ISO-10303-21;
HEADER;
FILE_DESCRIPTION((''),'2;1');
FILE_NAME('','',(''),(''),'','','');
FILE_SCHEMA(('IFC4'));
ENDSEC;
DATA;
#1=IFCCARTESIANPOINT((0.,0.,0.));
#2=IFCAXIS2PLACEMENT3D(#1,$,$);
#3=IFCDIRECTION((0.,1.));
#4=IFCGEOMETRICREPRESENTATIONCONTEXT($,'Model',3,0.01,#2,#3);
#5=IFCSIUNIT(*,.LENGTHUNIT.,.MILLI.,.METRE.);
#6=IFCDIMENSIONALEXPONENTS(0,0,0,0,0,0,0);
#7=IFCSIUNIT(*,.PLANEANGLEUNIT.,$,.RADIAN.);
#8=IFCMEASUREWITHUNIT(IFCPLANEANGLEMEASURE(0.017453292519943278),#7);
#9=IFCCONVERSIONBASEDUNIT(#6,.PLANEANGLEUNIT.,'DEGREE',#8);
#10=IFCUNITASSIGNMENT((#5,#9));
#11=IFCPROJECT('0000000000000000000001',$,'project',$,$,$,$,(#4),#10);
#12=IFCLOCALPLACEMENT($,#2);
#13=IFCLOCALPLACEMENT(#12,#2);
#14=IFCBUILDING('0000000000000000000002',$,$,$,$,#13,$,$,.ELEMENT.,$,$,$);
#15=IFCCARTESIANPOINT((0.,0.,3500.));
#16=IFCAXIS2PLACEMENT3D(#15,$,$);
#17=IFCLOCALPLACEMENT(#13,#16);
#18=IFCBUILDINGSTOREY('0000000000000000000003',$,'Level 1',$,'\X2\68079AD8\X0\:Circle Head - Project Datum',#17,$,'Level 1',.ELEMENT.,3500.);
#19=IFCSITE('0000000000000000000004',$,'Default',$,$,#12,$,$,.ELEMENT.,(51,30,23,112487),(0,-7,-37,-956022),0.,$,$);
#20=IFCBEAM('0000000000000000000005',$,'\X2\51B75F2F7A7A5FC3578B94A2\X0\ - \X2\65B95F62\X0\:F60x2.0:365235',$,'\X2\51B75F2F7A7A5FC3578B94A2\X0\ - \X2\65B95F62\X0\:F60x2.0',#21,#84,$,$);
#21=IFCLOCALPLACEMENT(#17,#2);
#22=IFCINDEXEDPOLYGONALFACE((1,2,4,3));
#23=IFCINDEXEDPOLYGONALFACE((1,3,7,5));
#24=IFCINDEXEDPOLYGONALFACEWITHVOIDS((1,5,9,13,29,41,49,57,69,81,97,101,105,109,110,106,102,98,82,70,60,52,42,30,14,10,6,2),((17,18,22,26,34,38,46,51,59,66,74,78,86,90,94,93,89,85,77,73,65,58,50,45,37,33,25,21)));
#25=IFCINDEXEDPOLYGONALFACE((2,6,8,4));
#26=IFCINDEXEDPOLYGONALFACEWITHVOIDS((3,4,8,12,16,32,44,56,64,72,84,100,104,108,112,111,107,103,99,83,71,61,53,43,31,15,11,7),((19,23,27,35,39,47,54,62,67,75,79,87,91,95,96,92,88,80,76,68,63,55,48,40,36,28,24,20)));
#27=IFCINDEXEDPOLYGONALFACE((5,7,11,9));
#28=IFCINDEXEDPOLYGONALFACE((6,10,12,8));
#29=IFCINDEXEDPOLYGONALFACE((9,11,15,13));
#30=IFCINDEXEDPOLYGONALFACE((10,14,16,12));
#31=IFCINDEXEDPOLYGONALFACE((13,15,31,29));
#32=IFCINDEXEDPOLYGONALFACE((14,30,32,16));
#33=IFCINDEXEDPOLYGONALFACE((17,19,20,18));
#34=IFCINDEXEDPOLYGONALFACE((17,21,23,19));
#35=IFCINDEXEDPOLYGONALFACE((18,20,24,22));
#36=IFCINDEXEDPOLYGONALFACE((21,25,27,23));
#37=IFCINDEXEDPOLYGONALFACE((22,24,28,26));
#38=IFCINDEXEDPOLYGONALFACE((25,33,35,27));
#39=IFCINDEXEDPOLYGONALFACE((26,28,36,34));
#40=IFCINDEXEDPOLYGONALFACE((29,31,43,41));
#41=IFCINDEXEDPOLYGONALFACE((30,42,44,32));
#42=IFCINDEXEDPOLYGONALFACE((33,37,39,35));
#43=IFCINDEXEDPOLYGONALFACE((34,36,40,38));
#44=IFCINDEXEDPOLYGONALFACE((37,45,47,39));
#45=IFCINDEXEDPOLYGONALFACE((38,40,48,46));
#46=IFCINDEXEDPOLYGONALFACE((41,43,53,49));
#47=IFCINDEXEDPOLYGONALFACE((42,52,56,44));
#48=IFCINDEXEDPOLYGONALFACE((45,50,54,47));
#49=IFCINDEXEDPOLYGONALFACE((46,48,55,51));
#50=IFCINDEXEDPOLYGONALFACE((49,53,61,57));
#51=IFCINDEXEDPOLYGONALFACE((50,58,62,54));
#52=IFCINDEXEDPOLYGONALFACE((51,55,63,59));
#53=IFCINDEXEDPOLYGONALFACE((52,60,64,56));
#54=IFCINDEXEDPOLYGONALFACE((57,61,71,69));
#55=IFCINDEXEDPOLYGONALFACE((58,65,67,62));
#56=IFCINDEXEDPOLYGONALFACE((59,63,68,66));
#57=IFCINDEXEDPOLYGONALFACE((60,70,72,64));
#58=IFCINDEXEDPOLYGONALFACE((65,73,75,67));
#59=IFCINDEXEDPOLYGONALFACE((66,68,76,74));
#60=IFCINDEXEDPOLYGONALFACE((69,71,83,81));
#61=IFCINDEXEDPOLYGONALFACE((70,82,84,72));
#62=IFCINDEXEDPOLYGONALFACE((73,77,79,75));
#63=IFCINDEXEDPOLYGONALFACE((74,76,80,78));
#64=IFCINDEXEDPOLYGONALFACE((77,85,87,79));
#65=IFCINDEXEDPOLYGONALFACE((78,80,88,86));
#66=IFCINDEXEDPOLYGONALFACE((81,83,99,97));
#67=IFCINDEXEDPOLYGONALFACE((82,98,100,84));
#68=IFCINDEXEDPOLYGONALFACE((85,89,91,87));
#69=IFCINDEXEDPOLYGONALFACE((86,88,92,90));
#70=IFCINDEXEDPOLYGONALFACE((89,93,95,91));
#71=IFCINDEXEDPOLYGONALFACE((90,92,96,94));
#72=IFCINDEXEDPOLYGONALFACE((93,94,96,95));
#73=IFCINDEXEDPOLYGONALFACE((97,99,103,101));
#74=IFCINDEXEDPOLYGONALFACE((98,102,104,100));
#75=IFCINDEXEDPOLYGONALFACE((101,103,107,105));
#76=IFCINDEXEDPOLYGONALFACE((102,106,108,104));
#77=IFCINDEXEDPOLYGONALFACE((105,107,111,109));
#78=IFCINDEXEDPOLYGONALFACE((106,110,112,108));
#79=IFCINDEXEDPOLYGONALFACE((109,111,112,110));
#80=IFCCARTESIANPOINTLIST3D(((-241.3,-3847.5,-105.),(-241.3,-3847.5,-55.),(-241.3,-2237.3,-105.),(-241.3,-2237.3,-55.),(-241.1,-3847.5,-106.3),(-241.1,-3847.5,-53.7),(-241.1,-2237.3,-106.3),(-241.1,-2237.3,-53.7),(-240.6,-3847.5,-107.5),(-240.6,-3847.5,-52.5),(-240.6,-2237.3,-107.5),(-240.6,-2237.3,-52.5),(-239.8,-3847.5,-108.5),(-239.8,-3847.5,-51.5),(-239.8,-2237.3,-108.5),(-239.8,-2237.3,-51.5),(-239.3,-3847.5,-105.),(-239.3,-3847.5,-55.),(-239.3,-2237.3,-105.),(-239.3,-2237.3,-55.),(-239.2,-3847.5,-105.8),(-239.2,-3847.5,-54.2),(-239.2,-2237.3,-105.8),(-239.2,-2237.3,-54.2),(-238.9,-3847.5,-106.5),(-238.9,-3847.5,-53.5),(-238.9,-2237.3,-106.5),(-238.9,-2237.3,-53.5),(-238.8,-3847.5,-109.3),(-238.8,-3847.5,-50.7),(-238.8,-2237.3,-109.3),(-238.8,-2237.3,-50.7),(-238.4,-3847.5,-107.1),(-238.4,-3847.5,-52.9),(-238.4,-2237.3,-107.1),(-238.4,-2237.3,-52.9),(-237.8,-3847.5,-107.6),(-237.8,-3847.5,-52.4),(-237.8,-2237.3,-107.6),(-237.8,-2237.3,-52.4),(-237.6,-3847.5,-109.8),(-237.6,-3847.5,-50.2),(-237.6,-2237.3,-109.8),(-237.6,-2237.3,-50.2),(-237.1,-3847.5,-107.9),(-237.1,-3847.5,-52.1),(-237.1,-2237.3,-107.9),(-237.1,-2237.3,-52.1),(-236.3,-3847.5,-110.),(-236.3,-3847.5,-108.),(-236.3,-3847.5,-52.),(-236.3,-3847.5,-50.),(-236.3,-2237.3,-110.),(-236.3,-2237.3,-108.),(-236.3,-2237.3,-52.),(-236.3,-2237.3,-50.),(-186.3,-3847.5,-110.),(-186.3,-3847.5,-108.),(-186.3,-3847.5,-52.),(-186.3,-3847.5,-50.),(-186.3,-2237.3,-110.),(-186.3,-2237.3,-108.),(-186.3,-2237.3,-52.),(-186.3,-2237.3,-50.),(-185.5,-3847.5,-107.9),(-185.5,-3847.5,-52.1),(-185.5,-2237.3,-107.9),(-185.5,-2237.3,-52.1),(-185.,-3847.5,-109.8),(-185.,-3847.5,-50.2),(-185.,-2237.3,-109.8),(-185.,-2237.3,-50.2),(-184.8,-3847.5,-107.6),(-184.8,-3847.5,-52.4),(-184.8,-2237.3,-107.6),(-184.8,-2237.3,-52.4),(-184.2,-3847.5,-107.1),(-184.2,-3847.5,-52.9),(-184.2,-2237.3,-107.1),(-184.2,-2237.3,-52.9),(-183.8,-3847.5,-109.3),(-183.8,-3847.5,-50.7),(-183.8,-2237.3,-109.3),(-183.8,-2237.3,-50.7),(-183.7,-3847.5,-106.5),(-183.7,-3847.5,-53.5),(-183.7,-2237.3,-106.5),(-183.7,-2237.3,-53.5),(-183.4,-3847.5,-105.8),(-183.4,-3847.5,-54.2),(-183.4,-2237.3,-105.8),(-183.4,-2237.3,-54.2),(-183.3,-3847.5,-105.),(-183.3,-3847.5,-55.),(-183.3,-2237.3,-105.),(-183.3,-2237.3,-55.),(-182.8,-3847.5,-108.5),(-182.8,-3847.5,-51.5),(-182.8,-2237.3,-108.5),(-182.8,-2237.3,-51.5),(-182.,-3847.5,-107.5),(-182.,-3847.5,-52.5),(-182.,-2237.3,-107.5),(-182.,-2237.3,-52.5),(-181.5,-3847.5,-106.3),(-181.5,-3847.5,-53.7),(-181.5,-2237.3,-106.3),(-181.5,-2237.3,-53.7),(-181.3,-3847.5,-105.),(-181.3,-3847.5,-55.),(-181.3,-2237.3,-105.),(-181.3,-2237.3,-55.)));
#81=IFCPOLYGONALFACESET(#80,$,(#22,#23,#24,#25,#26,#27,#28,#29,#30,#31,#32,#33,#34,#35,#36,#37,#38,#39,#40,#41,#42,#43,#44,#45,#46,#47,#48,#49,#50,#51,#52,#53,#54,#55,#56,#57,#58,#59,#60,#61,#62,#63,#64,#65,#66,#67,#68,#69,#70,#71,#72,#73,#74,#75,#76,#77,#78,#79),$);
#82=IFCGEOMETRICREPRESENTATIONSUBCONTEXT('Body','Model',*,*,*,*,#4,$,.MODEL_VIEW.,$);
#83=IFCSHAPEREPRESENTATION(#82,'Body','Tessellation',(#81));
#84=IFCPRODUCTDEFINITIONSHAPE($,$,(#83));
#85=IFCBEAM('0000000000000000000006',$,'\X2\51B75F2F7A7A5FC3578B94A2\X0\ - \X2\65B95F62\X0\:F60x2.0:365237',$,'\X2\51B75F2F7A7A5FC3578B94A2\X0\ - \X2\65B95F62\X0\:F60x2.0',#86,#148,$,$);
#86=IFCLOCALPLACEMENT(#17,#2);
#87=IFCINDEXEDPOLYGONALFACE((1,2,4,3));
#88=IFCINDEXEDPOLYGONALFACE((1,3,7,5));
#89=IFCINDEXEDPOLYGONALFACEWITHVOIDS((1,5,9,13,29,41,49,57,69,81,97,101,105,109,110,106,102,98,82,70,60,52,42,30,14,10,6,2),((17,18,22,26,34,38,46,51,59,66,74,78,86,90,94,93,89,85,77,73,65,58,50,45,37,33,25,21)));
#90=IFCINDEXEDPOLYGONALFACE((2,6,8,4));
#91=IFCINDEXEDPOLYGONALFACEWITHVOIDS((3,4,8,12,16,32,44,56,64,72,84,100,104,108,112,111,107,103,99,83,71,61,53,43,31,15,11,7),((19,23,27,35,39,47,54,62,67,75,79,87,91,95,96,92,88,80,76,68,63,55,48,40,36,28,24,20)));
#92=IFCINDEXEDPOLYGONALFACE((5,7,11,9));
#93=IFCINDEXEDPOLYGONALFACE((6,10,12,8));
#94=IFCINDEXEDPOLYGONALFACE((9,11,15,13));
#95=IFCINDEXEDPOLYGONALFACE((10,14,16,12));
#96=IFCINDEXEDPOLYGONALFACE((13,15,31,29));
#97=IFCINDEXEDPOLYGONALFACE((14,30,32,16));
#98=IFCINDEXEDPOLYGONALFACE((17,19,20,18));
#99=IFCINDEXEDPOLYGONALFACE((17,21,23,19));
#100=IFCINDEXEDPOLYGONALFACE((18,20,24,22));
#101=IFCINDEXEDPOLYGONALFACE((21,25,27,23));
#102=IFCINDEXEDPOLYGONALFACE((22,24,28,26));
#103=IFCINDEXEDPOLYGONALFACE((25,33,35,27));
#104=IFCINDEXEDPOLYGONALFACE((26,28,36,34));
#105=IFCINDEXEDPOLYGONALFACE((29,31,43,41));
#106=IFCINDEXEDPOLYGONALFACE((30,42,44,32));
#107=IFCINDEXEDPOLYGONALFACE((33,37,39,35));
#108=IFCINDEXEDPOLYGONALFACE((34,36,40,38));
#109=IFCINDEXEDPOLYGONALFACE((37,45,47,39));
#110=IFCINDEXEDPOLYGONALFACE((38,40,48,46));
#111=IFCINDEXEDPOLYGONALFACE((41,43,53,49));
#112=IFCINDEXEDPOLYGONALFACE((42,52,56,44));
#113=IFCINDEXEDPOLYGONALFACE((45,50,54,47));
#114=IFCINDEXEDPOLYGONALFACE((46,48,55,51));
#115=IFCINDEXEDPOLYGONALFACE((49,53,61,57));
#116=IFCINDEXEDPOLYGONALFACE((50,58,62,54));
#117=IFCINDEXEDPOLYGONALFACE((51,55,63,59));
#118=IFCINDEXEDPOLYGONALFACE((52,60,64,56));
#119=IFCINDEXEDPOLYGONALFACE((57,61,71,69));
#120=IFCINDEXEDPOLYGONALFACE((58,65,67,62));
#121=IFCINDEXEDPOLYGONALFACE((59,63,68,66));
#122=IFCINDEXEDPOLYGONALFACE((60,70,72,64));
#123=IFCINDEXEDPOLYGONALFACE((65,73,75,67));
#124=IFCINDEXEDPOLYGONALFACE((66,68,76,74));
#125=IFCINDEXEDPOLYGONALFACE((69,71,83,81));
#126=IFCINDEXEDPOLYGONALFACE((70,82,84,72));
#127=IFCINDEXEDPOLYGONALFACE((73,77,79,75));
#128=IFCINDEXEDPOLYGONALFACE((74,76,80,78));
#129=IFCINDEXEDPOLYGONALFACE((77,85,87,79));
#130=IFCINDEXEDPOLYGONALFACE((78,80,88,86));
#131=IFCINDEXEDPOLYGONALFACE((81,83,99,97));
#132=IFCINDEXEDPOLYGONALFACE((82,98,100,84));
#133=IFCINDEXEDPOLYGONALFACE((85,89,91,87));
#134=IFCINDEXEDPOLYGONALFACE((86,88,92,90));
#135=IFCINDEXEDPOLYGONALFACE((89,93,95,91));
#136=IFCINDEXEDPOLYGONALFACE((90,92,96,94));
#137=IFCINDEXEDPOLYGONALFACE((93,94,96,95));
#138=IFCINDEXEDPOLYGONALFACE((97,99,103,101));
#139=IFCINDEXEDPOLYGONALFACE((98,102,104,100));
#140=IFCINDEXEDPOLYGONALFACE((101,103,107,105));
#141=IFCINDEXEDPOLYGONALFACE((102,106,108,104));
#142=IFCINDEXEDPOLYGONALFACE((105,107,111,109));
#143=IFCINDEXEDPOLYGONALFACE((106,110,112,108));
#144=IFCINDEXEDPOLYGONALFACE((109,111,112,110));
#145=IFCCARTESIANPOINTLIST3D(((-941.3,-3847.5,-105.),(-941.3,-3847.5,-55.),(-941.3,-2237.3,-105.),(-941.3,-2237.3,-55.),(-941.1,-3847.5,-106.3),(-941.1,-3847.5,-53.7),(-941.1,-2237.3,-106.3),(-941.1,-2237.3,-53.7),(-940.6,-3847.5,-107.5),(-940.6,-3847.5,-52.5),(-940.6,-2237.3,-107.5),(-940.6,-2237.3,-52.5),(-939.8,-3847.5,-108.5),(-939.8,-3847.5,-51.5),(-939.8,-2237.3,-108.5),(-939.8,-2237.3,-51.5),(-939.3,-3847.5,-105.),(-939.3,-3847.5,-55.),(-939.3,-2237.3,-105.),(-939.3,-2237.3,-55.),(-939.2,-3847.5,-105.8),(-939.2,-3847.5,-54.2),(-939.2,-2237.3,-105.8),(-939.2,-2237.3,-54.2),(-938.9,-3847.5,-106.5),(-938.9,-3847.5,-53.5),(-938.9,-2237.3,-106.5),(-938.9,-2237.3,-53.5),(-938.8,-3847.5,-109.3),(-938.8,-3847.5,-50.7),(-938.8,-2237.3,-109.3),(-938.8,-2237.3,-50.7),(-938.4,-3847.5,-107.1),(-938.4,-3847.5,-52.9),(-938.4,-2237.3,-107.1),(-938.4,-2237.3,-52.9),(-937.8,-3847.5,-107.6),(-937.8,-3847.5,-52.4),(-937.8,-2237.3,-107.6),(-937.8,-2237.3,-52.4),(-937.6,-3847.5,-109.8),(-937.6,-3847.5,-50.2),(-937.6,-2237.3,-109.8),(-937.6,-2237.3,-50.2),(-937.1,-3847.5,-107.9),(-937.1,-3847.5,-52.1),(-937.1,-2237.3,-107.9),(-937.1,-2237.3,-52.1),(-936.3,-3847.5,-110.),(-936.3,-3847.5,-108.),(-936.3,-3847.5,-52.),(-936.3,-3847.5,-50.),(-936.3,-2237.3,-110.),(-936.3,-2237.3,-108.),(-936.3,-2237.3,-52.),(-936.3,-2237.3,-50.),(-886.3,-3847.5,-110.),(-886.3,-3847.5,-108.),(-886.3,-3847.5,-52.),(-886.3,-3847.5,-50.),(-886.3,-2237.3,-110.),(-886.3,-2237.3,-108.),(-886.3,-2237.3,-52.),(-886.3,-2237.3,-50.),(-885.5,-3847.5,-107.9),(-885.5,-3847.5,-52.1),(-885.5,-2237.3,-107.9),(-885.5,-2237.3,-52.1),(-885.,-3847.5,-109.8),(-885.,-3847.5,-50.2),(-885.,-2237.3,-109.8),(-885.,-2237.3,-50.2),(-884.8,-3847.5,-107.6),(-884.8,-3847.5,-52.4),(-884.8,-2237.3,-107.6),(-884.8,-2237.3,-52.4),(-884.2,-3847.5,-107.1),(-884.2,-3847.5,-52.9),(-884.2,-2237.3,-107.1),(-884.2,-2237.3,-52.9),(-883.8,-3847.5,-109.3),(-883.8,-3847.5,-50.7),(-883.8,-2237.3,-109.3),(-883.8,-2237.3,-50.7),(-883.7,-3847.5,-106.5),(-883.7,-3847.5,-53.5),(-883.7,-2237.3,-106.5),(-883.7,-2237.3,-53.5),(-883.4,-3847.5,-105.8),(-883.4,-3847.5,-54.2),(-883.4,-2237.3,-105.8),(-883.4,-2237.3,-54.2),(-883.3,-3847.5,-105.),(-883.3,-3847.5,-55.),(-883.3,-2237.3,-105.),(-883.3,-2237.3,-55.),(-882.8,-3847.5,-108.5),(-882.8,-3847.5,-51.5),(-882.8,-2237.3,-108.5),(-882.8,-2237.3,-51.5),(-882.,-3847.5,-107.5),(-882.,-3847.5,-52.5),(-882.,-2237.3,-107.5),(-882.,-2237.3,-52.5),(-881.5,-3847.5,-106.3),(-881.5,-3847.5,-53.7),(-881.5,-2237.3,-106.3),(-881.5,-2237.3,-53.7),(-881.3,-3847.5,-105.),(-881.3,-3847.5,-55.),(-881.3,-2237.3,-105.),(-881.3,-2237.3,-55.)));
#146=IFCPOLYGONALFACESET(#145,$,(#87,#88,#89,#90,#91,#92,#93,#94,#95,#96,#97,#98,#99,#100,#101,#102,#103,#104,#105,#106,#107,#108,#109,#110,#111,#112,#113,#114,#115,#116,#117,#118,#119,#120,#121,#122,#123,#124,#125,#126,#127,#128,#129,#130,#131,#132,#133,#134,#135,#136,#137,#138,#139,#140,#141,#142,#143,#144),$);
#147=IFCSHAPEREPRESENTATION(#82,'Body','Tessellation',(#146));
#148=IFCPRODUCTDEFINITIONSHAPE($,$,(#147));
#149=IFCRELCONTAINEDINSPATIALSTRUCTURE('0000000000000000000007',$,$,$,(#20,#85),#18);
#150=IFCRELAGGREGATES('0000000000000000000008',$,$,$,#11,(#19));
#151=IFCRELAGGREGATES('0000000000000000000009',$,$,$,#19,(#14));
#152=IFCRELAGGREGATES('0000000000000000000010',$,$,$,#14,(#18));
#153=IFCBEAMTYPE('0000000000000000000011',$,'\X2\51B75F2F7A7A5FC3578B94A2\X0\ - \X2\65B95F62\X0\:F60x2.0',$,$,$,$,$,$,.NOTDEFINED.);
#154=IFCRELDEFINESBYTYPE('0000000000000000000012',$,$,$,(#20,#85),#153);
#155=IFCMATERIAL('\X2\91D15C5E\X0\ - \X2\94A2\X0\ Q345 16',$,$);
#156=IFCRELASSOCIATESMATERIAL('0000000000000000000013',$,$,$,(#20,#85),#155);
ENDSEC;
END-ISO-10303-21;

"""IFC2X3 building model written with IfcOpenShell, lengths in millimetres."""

from ifc_helpers import new_model, entity, si_unit, converted_unit, direction, frame, frame_2d, origin, place, context, subcontext, project, spatial, polyline, circle_curve, parameter, trimmed, segment, composite_curve, outline, extrude, material, type_object, element, save


model = new_model("IFC2X3")

# Units and contexts
model_context = context("Model", 3, precision=0.01, world=origin(), true_north=direction((0.0, 1.0)))
body_context = subcontext(model_context, "Body", "Model", "MODEL_VIEW")
ifc_project = project(units=[si_unit("LENGTHUNIT", "METRE", prefix="MILLI"), converted_unit("PLANEANGLEUNIT", "DEGREE", entity("IfcPlaneAngleMeasure", 0.017453292519943278), si_unit("PLANEANGLEUNIT", "RADIAN"), dimensions=[0, 0, 0, 0, 0, 0, 0])], contexts=[model_context])

# Site, building, storey
site_placement = place(None, origin())
site = spatial("IfcSite", under=ifc_project, at=site_placement, Name="Default", CompositionType="ELEMENT", RefLatitude=(51, 30, 23, 112487), RefLongitude=(0, -7, -37, -956022), RefElevation=0.0)
building_placement = place(site_placement, origin())
building = spatial("IfcBuilding", under=site, at=building_placement, CompositionType="ELEMENT")
storey_placement = place(building_placement, frame((0.0, 0.0, 3500.0)))
storey = spatial("IfcBuildingStorey", under=building, at=storey_placement, Name="Level 1", ObjectType="标高:Circle Head - Project Datum", LongName="Level 1", CompositionType="ELEMENT", Elevation=3500.0)

# Beams
ifc_material_1 = material(Name="金属 - 钢 Q345 16")
beam_type_1 = type_object("IfcBeamType", Name="冷弯空心型钢 - 方形:F60x2.0", PredefinedType="NOTDEFINED")
beam_1_placement = place(storey_placement, frame((-211.3, -3815.6, -50.0), z_axis=(0.0, 0.0, 1.0), x_axis=(0.0, 1.0, 0.0)))
element("IfcBeam", 1, at=beam_1_placement, inside=storey, type_object=beam_type_1, material=ifc_material_1, Name="冷弯空心型钢 - 方形:F60x2.0:365235", ObjectType="冷弯空心型钢 - 方形:F60x2.0", context=body_context, shape_type="SweptSolid", body=[
    extrude(outline(composite_curve([segment(polyline([(-25.0, -30.0), (25.0, -30.0)]), True, "CONTINUOUS"), segment(trimmed(circle_curve(frame_2d((25.0, -25.0), x_axis=(1.0, 0.0)), 5.0), [parameter(270.0)], [parameter(360.0)], True, "PARAMETER"), True, "CONTINUOUS"), segment(polyline([(30.0, -25.0), (30.0, 25.0)]), True, "CONTINUOUS"), segment(trimmed(circle_curve(frame_2d((25.0, 25.0), x_axis=(1.0, 0.0)), 5.0), [parameter(360.0)], [parameter(90.0)], True, "PARAMETER"), True, "CONTINUOUS"), segment(polyline([(25.0, 30.0), (-25.0, 30.0)]), True, "CONTINUOUS"), segment(trimmed(circle_curve(frame_2d((-25.0, 25.0), x_axis=(1.0, 0.0)), 5.0), [parameter(90.0)], [parameter(180.0)], True, "PARAMETER"), True, "CONTINUOUS"), segment(polyline([(-30.0, 25.0), (-30.0, -25.0)]), True, "CONTINUOUS"), segment(trimmed(circle_curve(frame_2d((-25.0, -25.0), x_axis=(1.0, 0.0)), 5.0), [parameter(180.0)], [parameter(270.0)], True, "PARAMETER"), True, "CONTINUOUS")], self_intersect=False), holes=[composite_curve([segment(trimmed(circle_curve(frame_2d((-25.0, -25.0), x_axis=(1.0, 0.0)), 3.0), [parameter(180.0)], [parameter(270.0)], True, "PARAMETER"), False, "CONTINUOUS"), segment(polyline([(-28.0, -25.0), (-28.0, 25.0)]), True, "CONTINUOUS"), segment(trimmed(circle_curve(frame_2d((-25.0, 25.0), x_axis=(1.0, 0.0)), 3.0), [parameter(90.0)], [parameter(180.0)], True, "PARAMETER"), False, "CONTINUOUS"), segment(polyline([(-25.0, 28.0), (25.0, 28.0)]), True, "CONTINUOUS"), segment(trimmed(circle_curve(frame_2d((25.0, 25.0), x_axis=(1.0, 0.0)), 3.0), [parameter(0.0)], [parameter(90.0)], True, "PARAMETER"), False, "CONTINUOUS"), segment(polyline([(28.0, 25.0), (28.0, -25.0)]), True, "CONTINUOUS"), segment(trimmed(circle_curve(frame_2d((25.0, -25.0), x_axis=(1.0, 0.0)), 3.0), [parameter(270.0)], [parameter(360.0)], True, "PARAMETER"), False, "CONTINUOUS"), segment(polyline([(25.0, -28.0), (-25.0, -28.0)]), True, "CONTINUOUS")], self_intersect=False)]), frame((-31.9, 0.0, -30.0), z_axis=(1.0, 0.0, 0.0), x_axis=(0.0, -1.0, 0.0)), (0.0, 0.0, 1.0), 1610.2),
])
beam_2_placement = place(storey_placement, frame((-911.3, -3815.6, -50.0), z_axis=(0.0, 0.0, 1.0), x_axis=(0.0, 1.0, 0.0)))
element("IfcBeam", 2, at=beam_2_placement, inside=storey, type_object=beam_type_1, material=ifc_material_1, Name="冷弯空心型钢 - 方形:F60x2.0:365237", ObjectType="冷弯空心型钢 - 方形:F60x2.0", context=body_context, shape_type="SweptSolid", body=[
    extrude(outline(composite_curve([segment(polyline([(-25.0, -30.0), (25.0, -30.0)]), True, "CONTINUOUS"), segment(trimmed(circle_curve(frame_2d((25.0, -25.0), x_axis=(1.0, 0.0)), 5.0), [parameter(270.0)], [parameter(360.0)], True, "PARAMETER"), True, "CONTINUOUS"), segment(polyline([(30.0, -25.0), (30.0, 25.0)]), True, "CONTINUOUS"), segment(trimmed(circle_curve(frame_2d((25.0, 25.0), x_axis=(1.0, 0.0)), 5.0), [parameter(360.0)], [parameter(90.0)], True, "PARAMETER"), True, "CONTINUOUS"), segment(polyline([(25.0, 30.0), (-25.0, 30.0)]), True, "CONTINUOUS"), segment(trimmed(circle_curve(frame_2d((-25.0, 25.0), x_axis=(1.0, 0.0)), 5.0), [parameter(90.0)], [parameter(180.0)], True, "PARAMETER"), True, "CONTINUOUS"), segment(polyline([(-30.0, 25.0), (-30.0, -25.0)]), True, "CONTINUOUS"), segment(trimmed(circle_curve(frame_2d((-25.0, -25.0), x_axis=(1.0, 0.0)), 5.0), [parameter(180.0)], [parameter(270.0)], True, "PARAMETER"), True, "CONTINUOUS")], self_intersect=False), holes=[composite_curve([segment(trimmed(circle_curve(frame_2d((-25.0, -25.0), x_axis=(1.0, 0.0)), 3.0), [parameter(180.0)], [parameter(270.0)], True, "PARAMETER"), False, "CONTINUOUS"), segment(polyline([(-28.0, -25.0), (-28.0, 25.0)]), True, "CONTINUOUS"), segment(trimmed(circle_curve(frame_2d((-25.0, 25.0), x_axis=(1.0, 0.0)), 3.0), [parameter(90.0)], [parameter(180.0)], True, "PARAMETER"), False, "CONTINUOUS"), segment(polyline([(-25.0, 28.0), (25.0, 28.0)]), True, "CONTINUOUS"), segment(trimmed(circle_curve(frame_2d((25.0, 25.0), x_axis=(1.0, 0.0)), 3.0), [parameter(0.0)], [parameter(90.0)], True, "PARAMETER"), False, "CONTINUOUS"), segment(polyline([(28.0, 25.0), (28.0, -25.0)]), True, "CONTINUOUS"), segment(trimmed(circle_curve(frame_2d((25.0, -25.0), x_axis=(1.0, 0.0)), 3.0), [parameter(270.0)], [parameter(360.0)], True, "PARAMETER"), False, "CONTINUOUS"), segment(polyline([(25.0, -28.0), (-25.0, -28.0)]), True, "CONTINUOUS")], self_intersect=False)]), frame((-31.9, 0.0, -30.0), z_axis=(1.0, 0.0, 0.0), x_axis=(0.0, -1.0, 0.0)), (0.0, 0.0, 1.0), 1610.2),
])

save(model, "model.ifc")
